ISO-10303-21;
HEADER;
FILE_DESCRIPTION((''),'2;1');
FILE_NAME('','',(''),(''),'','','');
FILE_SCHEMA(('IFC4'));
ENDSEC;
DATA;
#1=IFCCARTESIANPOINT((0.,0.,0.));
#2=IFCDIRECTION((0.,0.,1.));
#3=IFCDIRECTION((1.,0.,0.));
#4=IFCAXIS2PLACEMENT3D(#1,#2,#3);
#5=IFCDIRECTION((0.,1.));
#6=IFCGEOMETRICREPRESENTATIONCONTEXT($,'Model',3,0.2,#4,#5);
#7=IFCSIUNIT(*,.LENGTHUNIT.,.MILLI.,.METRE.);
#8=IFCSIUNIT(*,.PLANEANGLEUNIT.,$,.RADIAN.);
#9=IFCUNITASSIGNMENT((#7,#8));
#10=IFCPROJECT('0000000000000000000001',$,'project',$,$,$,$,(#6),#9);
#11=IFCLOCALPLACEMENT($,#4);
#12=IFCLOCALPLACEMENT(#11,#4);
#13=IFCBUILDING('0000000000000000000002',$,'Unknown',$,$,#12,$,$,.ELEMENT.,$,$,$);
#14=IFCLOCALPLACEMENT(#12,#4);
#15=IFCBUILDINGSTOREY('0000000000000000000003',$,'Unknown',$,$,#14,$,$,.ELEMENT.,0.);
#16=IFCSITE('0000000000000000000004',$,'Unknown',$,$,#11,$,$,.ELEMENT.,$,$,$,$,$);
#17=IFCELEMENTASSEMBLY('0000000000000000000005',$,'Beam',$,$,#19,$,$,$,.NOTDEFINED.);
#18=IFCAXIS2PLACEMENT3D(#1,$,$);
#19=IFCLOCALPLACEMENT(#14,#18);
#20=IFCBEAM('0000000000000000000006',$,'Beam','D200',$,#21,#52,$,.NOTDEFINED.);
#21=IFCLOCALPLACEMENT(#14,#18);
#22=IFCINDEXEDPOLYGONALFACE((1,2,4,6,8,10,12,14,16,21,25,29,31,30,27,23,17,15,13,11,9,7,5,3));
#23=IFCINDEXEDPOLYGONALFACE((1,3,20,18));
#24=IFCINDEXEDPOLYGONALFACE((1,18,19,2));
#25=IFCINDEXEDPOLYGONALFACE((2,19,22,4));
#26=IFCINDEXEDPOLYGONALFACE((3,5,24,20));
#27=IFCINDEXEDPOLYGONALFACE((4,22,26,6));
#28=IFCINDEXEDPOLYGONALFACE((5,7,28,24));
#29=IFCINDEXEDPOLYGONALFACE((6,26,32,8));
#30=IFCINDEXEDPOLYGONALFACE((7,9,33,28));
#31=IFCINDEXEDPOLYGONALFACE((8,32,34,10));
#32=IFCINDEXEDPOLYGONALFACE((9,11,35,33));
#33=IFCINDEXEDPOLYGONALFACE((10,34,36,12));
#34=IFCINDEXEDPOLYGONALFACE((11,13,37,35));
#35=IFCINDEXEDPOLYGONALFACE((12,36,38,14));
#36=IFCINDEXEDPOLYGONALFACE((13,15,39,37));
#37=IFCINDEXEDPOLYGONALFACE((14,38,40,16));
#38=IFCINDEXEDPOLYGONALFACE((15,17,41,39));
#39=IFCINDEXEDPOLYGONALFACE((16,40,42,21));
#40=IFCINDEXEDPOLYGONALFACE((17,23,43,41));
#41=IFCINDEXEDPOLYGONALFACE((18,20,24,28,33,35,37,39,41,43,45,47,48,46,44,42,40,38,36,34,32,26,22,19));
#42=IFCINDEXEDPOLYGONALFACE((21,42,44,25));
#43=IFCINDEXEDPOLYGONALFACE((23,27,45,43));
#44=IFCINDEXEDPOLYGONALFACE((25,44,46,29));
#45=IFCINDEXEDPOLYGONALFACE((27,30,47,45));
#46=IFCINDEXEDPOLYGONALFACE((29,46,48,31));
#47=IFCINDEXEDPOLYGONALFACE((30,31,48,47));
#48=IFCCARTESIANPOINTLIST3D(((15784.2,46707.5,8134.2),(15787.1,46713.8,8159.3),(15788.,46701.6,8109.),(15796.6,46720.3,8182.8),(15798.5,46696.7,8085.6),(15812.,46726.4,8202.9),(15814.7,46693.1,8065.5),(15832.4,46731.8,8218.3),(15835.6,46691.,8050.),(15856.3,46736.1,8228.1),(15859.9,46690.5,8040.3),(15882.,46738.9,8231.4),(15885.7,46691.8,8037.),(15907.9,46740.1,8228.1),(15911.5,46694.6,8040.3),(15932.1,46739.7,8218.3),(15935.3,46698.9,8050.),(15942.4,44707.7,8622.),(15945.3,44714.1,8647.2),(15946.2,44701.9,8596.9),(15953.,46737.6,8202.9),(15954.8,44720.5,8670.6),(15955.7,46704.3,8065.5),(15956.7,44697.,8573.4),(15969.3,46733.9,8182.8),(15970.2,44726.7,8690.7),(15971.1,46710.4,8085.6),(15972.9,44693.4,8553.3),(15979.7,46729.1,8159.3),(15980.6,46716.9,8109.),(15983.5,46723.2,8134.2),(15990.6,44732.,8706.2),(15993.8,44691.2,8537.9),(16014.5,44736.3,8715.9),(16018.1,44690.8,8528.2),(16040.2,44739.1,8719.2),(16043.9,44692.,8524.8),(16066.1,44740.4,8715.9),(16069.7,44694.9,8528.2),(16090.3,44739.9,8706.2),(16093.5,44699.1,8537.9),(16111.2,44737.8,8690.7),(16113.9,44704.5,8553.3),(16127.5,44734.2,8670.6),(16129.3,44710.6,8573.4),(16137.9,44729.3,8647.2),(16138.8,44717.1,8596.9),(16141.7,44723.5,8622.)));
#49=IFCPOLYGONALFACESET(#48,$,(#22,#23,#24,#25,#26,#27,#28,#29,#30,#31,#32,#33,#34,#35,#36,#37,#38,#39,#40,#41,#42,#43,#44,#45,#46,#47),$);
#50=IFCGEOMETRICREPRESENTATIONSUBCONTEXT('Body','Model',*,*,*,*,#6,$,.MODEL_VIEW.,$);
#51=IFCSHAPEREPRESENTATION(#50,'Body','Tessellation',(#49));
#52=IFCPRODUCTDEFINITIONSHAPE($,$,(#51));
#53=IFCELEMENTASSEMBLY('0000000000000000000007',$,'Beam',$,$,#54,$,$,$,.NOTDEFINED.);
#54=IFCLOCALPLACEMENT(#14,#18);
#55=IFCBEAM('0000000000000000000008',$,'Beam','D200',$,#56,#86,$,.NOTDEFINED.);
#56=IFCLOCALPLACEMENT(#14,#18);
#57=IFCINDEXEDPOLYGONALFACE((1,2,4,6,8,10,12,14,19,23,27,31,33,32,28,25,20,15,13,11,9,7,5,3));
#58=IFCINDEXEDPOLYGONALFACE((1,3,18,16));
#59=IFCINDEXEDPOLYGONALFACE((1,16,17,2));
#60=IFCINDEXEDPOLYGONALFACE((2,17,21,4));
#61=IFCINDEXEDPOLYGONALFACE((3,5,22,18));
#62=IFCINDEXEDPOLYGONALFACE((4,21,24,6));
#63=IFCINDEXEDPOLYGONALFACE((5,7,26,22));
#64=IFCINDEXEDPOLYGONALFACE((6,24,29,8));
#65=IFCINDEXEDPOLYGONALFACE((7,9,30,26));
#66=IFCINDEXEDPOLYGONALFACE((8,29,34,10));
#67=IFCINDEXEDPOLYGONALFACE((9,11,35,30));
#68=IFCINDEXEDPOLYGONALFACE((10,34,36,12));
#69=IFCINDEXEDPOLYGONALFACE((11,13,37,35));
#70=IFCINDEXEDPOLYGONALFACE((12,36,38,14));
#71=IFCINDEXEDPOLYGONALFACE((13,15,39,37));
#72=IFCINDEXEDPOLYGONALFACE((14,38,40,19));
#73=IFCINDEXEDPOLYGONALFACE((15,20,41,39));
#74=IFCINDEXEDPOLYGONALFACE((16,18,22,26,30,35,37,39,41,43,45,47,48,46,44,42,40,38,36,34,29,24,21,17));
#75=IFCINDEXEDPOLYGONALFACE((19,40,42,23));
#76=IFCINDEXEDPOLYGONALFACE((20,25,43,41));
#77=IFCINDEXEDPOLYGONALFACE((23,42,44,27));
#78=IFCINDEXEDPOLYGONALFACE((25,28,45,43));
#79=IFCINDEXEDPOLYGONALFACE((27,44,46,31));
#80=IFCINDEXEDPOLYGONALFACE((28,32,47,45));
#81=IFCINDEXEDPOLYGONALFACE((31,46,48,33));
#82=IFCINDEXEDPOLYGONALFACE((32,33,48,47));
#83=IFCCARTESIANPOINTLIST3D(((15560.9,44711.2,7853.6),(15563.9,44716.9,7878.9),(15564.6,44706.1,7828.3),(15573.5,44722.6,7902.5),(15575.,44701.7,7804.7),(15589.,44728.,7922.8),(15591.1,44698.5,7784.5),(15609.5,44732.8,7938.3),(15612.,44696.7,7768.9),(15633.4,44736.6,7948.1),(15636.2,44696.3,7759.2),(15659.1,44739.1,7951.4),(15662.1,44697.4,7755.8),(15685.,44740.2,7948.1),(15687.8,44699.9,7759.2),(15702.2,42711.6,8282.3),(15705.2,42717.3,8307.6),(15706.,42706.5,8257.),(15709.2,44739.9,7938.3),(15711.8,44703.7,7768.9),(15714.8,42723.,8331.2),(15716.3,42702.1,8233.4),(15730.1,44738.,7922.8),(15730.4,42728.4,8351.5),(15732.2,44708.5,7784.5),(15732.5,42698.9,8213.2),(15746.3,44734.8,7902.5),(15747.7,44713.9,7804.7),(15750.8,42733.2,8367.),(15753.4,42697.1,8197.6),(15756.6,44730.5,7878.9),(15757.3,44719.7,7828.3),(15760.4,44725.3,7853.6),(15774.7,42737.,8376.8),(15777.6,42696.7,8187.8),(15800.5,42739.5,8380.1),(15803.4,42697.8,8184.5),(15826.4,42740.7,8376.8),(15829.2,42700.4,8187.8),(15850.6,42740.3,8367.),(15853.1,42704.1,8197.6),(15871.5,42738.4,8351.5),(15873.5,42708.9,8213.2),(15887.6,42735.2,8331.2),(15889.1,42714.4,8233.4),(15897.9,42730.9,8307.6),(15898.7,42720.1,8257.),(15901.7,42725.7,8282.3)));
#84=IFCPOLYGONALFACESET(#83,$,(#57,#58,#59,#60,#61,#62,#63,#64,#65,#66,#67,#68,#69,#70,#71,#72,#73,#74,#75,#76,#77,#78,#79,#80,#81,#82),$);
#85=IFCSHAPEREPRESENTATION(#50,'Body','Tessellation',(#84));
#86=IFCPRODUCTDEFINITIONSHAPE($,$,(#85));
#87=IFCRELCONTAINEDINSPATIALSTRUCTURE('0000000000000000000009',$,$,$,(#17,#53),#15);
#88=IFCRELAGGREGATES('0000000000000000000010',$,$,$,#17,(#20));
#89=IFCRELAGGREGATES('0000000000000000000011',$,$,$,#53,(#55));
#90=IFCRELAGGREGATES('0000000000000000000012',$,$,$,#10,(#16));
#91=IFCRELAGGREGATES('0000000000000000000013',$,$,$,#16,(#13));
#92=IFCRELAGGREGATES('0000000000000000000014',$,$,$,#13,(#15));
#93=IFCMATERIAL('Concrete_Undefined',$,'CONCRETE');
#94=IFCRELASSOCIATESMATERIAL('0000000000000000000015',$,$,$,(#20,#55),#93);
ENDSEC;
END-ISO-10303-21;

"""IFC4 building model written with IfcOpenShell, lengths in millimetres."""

from ifc_helpers import new_model, si_unit, direction, frame, origin_with_axes, place, context, subcontext, project, spatial, line, indexed_curve, outline, extrude, material, element, aggregate, save


model = new_model("IFC4")

# Units and contexts
model_context = context("Model", 3, precision=0.2, world=origin_with_axes(), true_north=direction((0.0, 1.0)))
body_context = subcontext(model_context, "Body", "Model", "MODEL_VIEW")
ifc_project = project(units=[si_unit("LENGTHUNIT", "METRE", prefix="MILLI"), si_unit("PLANEANGLEUNIT", "RADIAN")], contexts=[model_context])

# Site, building, storey
site_placement = place(None, origin_with_axes())
site = spatial("IfcSite", under=ifc_project, at=site_placement, Name="Unknown", CompositionType="ELEMENT")
building_placement = place(site_placement, origin_with_axes())
building = spatial("IfcBuilding", under=site, at=building_placement, Name="Unknown", CompositionType="ELEMENT")
storey_placement = place(building_placement, origin_with_axes())
storey = spatial("IfcBuildingStorey", under=building, at=storey_placement, Name="Unknown", CompositionType="ELEMENT", Elevation=0.0)

# Shared definitions
ifc_material = material(Name="Concrete_Undefined", Category="CONCRETE")

# Element assemblies, beams
assembly_1_placement = place(storey_placement, frame((15883.9, 46715.3, 8134.2), z_axis=(-0.996885, -0.078865, 0.0), x_axis=(0.076632, -0.968656, 0.236289)))
assembly_1 = element("IfcElementAssembly", 1, at=assembly_1_placement, inside=storey, Name="Beam", PredefinedType="NOTDEFINED")
beam_1_placement = place(assembly_1_placement, origin_with_axes())
beam_1 = element("IfcBeam", 2, at=beam_1_placement, material=ifc_material, Name="Beam", Description="D200", PredefinedType="NOTDEFINED", context=body_context, shape_type="SolidModel", body=[
    extrude(outline(indexed_curve([(100.0, 0.0), (96.6, 25.9), (86.6, 50.0), (70.7, 70.7), (50.0, 86.6), (25.9, 96.6), (0.0, 100.0), (-25.9, 96.6), (-50.0, 86.6), (-70.7, 70.7), (-86.6, 50.0), (-96.6, 25.9), (-100.0, 0.0), (-96.6, -25.9), (-86.6, -50.0), (-70.7, -70.7), (-50.0, -86.6), (-25.9, -96.6), (0.0, -100.0), (25.9, -96.6), (50.0, -86.6), (70.7, -70.7), (86.6, -50.0), (96.6, -25.9)], segments=[line(1, 2, 3, 4, 5, 6, 7, 8, 9, 10, 11, 12, 13, 14, 15, 16, 17, 18, 19, 20, 21, 22, 23, 24, 1)])), frame((0.0, 0.0, 0.0), z_axis=(-1.0, 0.0, 0.0), x_axis=(0.0, 0.0, 1.0)), (0.0, 0.0, -1.0), 2064.5),
])
aggregate(assembly_1, [beam_1])
assembly_2_placement = place(storey_placement, frame((15660.6, 44718.3, 7853.6), z_axis=(-0.99751, -0.070519, 0.0), x_axis=(0.06896, -0.975453, 0.20913)))
assembly_2 = element("IfcElementAssembly", 3, at=assembly_2_placement, inside=storey, Name="Beam", PredefinedType="NOTDEFINED")
beam_2_placement = place(assembly_2_placement, origin_with_axes())
beam_2 = element("IfcBeam", 4, at=beam_2_placement, material=ifc_material, Name="Beam", Description="D200", PredefinedType="NOTDEFINED", context=body_context, shape_type="SolidModel", body=[
    extrude(outline(indexed_curve([(100.0, 0.0), (96.6, 25.9), (86.6, 50.0), (70.7, 70.7), (50.0, 86.6), (25.9, 96.6), (0.0, 100.0), (-25.9, 96.6), (-50.0, 86.6), (-70.7, 70.7), (-86.6, 50.0), (-96.6, 25.9), (-100.0, 0.0), (-96.6, -25.9), (-86.6, -50.0), (-70.7, -70.7), (-50.0, -86.6), (-25.9, -96.6), (0.0, -100.0), (25.9, -96.6), (50.0, -86.6), (70.7, -70.7), (86.6, -50.0), (96.6, -25.9)], segments=[line(1, 2, 3, 4, 5, 6, 7, 8, 9, 10, 11, 12, 13, 14, 15, 16, 17, 18, 19, 20, 21, 22, 23, 24, 1)])), frame((0.0, 0.0, 0.0), z_axis=(-1.0, 0.0, 0.0), x_axis=(0.0, 0.0, 1.0)), (0.0, 0.0, -1.0), 2049.9),
])
aggregate(assembly_2, [beam_2])

save(model, "model.ifc")
